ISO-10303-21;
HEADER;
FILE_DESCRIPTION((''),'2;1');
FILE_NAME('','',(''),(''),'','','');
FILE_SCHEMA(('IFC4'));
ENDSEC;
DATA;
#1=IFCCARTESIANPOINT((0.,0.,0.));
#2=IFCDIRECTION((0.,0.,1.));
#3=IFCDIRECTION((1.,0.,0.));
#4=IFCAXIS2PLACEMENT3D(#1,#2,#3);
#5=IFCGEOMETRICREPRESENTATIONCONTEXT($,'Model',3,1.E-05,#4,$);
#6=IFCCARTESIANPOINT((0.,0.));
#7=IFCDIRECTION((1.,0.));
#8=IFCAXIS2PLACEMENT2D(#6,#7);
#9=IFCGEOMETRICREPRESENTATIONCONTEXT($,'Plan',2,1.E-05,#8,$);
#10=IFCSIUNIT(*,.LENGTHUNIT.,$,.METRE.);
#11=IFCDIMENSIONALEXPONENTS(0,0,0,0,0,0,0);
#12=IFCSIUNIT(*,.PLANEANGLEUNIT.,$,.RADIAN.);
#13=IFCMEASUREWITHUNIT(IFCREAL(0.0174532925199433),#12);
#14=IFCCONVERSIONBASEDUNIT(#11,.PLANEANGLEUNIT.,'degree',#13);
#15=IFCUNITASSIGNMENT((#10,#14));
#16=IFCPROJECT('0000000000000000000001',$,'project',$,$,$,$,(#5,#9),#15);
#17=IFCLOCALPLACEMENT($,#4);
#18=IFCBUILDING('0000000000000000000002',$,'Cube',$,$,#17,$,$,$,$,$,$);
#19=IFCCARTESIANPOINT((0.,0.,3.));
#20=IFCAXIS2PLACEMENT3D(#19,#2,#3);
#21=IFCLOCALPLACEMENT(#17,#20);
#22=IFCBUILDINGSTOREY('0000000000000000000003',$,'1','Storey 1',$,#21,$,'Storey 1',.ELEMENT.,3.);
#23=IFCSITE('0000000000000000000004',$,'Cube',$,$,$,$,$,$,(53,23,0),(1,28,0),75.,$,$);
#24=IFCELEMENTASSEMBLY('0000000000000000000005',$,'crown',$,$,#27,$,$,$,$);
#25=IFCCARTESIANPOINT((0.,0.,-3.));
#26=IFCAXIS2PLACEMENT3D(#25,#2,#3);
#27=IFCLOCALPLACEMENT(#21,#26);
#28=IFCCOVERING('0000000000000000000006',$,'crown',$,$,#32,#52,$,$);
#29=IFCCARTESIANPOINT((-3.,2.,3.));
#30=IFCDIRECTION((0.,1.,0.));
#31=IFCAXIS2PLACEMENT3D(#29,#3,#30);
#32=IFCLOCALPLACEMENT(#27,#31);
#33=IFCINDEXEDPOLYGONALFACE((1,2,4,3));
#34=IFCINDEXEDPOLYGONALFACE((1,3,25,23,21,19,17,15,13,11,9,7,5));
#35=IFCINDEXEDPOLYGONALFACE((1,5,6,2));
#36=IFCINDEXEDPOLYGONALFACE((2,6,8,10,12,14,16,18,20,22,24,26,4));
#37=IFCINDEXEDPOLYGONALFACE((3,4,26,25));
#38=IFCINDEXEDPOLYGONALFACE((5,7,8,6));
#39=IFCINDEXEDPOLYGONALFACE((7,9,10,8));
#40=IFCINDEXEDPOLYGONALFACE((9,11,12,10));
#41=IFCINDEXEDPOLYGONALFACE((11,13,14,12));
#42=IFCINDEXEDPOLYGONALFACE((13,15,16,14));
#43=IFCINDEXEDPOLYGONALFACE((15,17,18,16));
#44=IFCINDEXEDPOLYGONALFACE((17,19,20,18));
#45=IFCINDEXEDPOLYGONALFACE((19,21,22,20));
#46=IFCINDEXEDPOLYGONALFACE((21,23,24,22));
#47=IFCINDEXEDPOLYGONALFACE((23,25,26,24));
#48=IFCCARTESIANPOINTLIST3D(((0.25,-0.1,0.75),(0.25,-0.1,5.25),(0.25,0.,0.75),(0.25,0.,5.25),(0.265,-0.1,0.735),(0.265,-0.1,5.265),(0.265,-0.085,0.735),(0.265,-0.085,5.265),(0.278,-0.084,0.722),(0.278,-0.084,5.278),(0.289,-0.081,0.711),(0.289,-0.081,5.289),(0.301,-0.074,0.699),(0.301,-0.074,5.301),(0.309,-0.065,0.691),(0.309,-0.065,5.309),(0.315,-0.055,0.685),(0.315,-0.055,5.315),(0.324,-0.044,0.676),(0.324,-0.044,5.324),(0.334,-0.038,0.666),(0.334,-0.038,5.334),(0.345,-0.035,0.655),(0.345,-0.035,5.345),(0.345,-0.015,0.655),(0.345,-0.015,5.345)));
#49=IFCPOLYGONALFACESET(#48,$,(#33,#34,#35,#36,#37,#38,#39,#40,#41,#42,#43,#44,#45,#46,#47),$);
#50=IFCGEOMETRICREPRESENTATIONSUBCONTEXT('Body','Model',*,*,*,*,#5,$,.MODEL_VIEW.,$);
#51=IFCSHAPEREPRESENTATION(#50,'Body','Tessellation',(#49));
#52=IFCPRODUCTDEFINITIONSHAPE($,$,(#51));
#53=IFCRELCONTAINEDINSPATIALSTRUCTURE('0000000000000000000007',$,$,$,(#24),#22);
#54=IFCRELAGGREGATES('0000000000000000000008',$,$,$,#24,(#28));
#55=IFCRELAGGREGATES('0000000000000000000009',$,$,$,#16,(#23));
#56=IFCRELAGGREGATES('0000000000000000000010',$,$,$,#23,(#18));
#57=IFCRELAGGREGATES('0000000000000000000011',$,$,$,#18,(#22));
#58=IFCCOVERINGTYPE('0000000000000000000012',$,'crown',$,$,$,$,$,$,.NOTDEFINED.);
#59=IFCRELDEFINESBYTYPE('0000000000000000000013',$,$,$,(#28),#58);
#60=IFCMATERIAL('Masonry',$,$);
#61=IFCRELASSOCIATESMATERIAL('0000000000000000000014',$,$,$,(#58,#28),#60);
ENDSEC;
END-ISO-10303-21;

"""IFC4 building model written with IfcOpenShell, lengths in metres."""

from ifc_helpers import new_model, entity, si_unit, converted_unit, frame, origin_with_axes, origin_2d_with_axis, place, context, subcontext, project, spatial, polyline, outline, extrude, clip, halfspace, material, material_profile, profile_set, profile_usage, type_object, element, aggregate, save


model = new_model("IFC4")

# Units and contexts
model_context = context("Model", 3, precision=1e-05, world=origin_with_axes())
plan_context = context("Plan", 2, precision=1e-05, world=origin_2d_with_axis())
body_context = subcontext(model_context, "Body", "Model", "MODEL_VIEW")
ifc_project = project(units=[si_unit("LENGTHUNIT", "METRE"), converted_unit("PLANEANGLEUNIT", "degree", entity("IfcReal", 0.0174532925199433), si_unit("PLANEANGLEUNIT", "RADIAN"), dimensions=[0, 0, 0, 0, 0, 0, 0])], contexts=[model_context, plan_context])

# Site, building, storey
site = spatial("IfcSite", under=ifc_project, Name="Cube", RefLatitude=(53, 23, 0), RefLongitude=(1, 28, 0), RefElevation=75.0)
building_placement = place(None, origin_with_axes())
building = spatial("IfcBuilding", under=site, at=building_placement, Name="Cube")
storey_placement = place(building_placement, frame((0.0, 0.0, 3.0), z_axis=(0.0, 0.0, 1.0), x_axis=(1.0, 0.0, 0.0)))
storey = spatial("IfcBuildingStorey", under=building, at=storey_placement, Name="1", Description="Storey 1", LongName="Storey 1", CompositionType="ELEMENT", Elevation=3.0)

# Shared definitions
ifc_material_1 = material(Name="Masonry")

# Element assembly, covering
assembly_1_placement = place(storey_placement, frame((0.0, 0.0, -3.0), z_axis=(0.0, 0.0, 1.0), x_axis=(1.0, 0.0, 0.0)))
assembly_1 = element("IfcElementAssembly", 1, at=assembly_1_placement, inside=storey, Name="crown")
ifc_material_profile_1 = material_profile(ifc_material_1, outline(polyline([(0.25, -0.1), (0.265, -0.1), (0.265, -0.085), (0.278, -0.084), (0.289, -0.081), (0.301, -0.074), (0.309, -0.065), (0.315, -0.055), (0.324, -0.044), (0.334, -0.038), (0.345, -0.035), (0.345, -0.015), (0.25, 0.0), (0.25, -0.1)])))
ifc_profile_set_1 = profile_set([ifc_material_profile_1])
covering_type_1 = type_object("IfcCoveringType", Name="crown", PredefinedType="NOTDEFINED", material=ifc_profile_set_1)
ifc_profile_usage_1 = profile_usage(ifc_profile_set_1)
covering_1_placement = place(assembly_1_placement, frame((-3.0, 2.0, 3.0), z_axis=(1.0, 0.0, 0.0), x_axis=(0.0, 1.0, 0.0)))
covering_1 = element("IfcCovering", 2, at=covering_1_placement, type_object=covering_type_1, material=ifc_profile_usage_1, Name="crown", context=body_context, shape_type="Clipping", body=[
    clip(clip(extrude(outline(polyline([(0.25, -0.1), (0.265, -0.1), (0.265, -0.085), (0.278, -0.084), (0.289, -0.081), (0.301, -0.074), (0.309, -0.065), (0.315, -0.055), (0.324, -0.044), (0.334, -0.038), (0.345, -0.035), (0.345, -0.015), (0.25, 0.0), (0.25, -0.1)])), origin_with_axes(), (0.0, 0.0, 1.0), 6.0), halfspace(frame((0.0, -3.0, 1.0), z_axis=(-0.707107, 0.0, -0.707107), x_axis=(0.0, 1.0, 0.0)), False)), halfspace(frame((0.0, -3.0, 5.0), z_axis=(-0.707107, 0.0, 0.707107), x_axis=(0.0, 1.0, 0.0)), False)),
])
aggregate(assembly_1, [covering_1])

save(model, "model.ifc")
